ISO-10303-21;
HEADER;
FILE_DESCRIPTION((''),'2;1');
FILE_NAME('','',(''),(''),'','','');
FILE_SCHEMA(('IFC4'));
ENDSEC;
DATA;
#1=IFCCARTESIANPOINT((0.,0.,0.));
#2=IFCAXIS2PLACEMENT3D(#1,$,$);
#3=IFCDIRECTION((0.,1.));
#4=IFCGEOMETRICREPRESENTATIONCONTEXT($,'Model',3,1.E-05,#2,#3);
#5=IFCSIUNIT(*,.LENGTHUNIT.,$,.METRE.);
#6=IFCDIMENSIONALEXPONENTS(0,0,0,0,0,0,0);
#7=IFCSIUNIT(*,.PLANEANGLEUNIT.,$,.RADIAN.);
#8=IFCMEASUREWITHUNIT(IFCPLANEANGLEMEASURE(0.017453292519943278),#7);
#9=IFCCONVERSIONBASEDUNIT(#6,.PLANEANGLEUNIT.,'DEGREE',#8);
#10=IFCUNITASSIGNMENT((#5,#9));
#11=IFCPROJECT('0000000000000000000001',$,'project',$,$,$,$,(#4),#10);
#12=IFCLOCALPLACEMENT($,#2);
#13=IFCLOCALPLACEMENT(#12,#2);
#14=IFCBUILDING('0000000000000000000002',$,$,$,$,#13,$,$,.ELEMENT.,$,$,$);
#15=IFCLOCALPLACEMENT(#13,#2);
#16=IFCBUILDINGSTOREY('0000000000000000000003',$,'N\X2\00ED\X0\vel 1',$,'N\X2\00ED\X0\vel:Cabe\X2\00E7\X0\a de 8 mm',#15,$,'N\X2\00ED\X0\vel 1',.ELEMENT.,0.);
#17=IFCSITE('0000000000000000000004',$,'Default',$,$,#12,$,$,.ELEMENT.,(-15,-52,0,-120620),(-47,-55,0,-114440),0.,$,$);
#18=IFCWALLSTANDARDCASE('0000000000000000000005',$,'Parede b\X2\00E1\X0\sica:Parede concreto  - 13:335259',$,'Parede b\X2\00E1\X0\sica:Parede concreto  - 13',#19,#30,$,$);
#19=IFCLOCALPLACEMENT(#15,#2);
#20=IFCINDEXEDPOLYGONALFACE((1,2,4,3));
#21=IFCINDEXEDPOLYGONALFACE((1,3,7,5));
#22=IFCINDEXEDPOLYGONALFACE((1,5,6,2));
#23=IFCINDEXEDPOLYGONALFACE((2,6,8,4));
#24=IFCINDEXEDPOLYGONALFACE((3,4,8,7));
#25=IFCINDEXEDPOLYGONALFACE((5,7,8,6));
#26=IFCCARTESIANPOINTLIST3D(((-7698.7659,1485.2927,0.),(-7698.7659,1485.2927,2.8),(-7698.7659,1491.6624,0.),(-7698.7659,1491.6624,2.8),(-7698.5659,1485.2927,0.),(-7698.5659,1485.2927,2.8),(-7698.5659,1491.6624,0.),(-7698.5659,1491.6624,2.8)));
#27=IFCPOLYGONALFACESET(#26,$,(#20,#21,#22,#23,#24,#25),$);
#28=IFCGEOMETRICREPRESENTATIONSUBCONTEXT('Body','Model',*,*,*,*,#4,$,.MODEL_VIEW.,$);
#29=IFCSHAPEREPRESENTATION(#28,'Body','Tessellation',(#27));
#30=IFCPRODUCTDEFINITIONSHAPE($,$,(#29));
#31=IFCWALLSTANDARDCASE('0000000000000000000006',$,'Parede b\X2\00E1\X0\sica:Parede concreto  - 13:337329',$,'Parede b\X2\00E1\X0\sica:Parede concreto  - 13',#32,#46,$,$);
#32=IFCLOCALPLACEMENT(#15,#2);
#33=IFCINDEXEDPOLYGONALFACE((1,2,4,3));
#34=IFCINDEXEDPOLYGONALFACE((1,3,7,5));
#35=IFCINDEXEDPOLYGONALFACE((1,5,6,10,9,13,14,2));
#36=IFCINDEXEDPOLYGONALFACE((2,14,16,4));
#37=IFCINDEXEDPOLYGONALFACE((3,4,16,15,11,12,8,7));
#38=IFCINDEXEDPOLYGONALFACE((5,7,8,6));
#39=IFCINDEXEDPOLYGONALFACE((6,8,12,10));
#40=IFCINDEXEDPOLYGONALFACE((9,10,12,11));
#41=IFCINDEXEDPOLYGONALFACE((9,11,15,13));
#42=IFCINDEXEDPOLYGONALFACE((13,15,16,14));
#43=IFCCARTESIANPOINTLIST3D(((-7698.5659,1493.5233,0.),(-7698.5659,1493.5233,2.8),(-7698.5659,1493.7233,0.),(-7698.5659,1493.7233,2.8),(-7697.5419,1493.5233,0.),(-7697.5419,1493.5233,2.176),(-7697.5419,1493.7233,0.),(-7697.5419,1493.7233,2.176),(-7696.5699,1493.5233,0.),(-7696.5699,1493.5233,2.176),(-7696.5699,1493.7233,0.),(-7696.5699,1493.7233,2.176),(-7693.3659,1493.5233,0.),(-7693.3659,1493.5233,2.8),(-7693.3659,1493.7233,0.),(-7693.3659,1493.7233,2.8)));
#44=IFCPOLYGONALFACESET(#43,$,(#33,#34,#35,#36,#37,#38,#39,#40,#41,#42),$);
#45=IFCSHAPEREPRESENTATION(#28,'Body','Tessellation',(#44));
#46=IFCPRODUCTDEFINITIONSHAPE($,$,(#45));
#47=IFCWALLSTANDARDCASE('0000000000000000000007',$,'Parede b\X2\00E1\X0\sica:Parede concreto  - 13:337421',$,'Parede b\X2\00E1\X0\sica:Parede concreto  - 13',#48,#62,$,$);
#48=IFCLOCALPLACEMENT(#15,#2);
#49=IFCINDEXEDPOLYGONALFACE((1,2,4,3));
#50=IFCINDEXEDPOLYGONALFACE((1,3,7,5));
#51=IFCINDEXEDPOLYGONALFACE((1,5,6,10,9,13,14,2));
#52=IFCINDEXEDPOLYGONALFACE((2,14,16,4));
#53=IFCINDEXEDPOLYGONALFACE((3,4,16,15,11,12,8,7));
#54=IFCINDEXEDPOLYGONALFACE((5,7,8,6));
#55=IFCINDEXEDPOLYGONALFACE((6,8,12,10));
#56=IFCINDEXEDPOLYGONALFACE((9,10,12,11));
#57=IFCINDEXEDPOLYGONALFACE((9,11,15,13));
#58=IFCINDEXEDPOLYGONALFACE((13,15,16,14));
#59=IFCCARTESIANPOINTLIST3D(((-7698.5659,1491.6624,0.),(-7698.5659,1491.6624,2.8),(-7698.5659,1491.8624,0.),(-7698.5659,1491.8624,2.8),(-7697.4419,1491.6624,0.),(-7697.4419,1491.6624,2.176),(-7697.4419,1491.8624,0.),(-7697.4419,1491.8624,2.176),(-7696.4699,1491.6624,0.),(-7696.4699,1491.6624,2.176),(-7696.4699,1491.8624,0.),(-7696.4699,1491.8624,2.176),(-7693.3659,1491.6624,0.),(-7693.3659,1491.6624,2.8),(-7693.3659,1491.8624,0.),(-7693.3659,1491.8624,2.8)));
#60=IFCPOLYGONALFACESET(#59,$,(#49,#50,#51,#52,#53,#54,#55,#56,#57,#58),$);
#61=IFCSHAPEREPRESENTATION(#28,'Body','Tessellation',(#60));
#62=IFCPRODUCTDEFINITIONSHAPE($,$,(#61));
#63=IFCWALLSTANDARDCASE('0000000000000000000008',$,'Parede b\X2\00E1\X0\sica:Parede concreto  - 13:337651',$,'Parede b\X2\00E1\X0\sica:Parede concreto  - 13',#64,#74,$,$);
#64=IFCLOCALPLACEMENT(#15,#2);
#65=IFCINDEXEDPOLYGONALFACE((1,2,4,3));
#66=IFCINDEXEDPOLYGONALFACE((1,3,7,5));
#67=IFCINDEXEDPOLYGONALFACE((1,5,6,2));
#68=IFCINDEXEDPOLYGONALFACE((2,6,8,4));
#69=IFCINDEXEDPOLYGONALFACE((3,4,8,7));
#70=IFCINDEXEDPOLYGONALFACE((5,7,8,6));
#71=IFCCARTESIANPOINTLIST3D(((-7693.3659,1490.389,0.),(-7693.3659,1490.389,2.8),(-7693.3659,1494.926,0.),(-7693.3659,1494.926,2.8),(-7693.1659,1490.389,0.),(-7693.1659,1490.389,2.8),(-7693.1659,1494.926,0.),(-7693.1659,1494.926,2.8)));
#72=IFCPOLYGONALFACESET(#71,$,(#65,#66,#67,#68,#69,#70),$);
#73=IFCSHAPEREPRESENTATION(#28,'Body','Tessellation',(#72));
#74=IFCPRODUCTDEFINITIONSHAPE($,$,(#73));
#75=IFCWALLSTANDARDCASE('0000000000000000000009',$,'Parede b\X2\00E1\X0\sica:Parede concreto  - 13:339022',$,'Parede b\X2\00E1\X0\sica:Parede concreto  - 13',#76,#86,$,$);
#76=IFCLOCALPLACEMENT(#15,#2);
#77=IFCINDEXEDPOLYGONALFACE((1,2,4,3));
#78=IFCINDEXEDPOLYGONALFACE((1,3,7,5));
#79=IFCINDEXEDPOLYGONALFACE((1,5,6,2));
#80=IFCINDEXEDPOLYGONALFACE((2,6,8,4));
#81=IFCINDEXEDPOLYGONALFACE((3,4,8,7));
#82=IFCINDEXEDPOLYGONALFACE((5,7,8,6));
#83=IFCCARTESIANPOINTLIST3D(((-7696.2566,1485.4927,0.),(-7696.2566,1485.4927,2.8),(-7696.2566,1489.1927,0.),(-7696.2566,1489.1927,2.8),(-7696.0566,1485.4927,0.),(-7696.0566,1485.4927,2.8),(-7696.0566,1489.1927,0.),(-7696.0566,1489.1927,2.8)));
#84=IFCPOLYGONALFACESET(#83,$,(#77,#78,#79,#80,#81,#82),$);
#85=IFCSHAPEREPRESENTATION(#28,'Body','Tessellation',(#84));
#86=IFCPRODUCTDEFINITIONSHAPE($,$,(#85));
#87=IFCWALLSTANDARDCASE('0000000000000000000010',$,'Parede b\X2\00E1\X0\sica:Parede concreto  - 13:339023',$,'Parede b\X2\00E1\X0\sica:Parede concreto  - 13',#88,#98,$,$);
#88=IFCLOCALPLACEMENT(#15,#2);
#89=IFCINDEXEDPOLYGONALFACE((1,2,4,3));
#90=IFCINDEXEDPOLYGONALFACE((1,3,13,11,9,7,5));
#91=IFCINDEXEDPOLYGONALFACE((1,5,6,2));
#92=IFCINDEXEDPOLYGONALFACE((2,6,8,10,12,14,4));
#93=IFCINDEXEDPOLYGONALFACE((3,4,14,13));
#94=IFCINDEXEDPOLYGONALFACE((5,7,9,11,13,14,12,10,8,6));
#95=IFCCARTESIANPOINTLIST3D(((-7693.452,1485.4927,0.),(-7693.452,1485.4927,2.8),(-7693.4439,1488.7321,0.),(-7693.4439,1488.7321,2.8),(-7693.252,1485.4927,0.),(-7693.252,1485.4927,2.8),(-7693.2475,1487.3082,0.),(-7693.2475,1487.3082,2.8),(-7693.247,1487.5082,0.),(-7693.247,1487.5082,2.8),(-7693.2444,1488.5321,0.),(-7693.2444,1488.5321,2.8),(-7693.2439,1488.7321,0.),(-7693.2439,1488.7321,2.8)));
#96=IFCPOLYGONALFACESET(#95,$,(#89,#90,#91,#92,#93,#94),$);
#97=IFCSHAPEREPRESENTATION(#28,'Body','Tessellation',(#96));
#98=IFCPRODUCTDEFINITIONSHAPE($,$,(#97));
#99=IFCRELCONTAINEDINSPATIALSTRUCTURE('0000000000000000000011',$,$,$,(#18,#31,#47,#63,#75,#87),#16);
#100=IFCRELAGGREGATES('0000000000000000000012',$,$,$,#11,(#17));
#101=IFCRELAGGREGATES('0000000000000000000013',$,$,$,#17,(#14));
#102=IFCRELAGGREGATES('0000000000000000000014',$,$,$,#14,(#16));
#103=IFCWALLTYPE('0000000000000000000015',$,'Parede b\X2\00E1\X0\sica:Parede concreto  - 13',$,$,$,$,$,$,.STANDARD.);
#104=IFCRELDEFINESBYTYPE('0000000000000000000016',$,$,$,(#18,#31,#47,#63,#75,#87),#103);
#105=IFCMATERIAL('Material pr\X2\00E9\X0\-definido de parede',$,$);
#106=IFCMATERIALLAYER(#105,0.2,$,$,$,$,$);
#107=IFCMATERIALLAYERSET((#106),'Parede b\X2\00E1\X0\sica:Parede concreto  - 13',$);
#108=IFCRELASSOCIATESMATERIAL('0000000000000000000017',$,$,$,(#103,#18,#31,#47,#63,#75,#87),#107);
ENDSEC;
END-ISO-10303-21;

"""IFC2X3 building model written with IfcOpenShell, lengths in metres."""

from ifc_helpers import new_model, entity, si_unit, converted_unit, direction, frame, frame_2d, origin, place, context, subcontext, project, spatial, polyline, rectangle, outline, extrude, material, layer, layer_set, layer_usage, type_object, element, save


model = new_model("IFC2X3")

# Units and contexts
model_context = context("Model", 3, precision=1e-05, world=origin(), true_north=direction((0.0, 1.0)))
body_context = subcontext(model_context, "Body", "Model", "MODEL_VIEW")
ifc_project = project(units=[si_unit("LENGTHUNIT", "METRE"), converted_unit("PLANEANGLEUNIT", "DEGREE", entity("IfcPlaneAngleMeasure", 0.017453292519943278), si_unit("PLANEANGLEUNIT", "RADIAN"), dimensions=[0, 0, 0, 0, 0, 0, 0])], contexts=[model_context])

# Site, building, storey
site_placement = place(None, origin())
site = spatial("IfcSite", under=ifc_project, at=site_placement, Name="Default", CompositionType="ELEMENT", RefLatitude=(-15, -52, 0, -120620), RefLongitude=(-47, -55, 0, -114440), RefElevation=0.0)
building_placement = place(site_placement, origin())
building = spatial("IfcBuilding", under=site, at=building_placement, CompositionType="ELEMENT")
storey_placement = place(building_placement, origin())
storey = spatial("IfcBuildingStorey", under=building, at=storey_placement, Name="Nível 1", ObjectType="Nível:Cabeça de 8 mm", LongName="Nível 1", CompositionType="ELEMENT", Elevation=0.0)

# Shared definitions
ifc_material_1 = material(Name="Material pré-definido de parede")
ifc_layer = layer(ifc_material_1, 0.2)
ifc_layer_set = layer_set([ifc_layer], Name="Parede básica:Parede concreto  - 13")
wall_type = type_object("IfcWallType", Name="Parede básica:Parede concreto  - 13", PredefinedType="STANDARD", material=ifc_layer_set)

# Wall
ifc_layer_usage_1 = layer_usage(ifc_layer_set, "AXIS2", "NEGATIVE", 0.1)
wall_1_placement = place(storey_placement, frame((-7698.6659, 1491.6624, 0.0), z_axis=(0.0, 0.0, 1.0), x_axis=(0.0, -1.0, 0.0)))
element("IfcWallStandardCase", 1, at=wall_1_placement, inside=storey, type_object=wall_type, material=ifc_layer_usage_1, Name="Parede básica:Parede concreto  - 13:335259", ObjectType="Parede básica:Parede concreto  - 13", context=body_context, shape_type="SweptSolid", body=[
    extrude(rectangle(XDim=6.3697, YDim=0.2, at=frame_2d((3.1848, 0.0), x_axis=(-1.0, 0.0))), origin(), (0.0, 0.0, 1.0), 2.8),
])

# Walls, openings
ifc_layer_usage_2 = layer_usage(ifc_layer_set, "AXIS2", "NEGATIVE", 0.1)
wall_2_placement = place(storey_placement, frame((-7698.5659, 1493.6233, 0.0)))
wall_2 = element("IfcWallStandardCase", 2, at=wall_2_placement, inside=storey, type_object=wall_type, material=ifc_layer_usage_2, Name="Parede básica:Parede concreto  - 13:337329", ObjectType="Parede básica:Parede concreto  - 13", context=body_context, shape_type="SweptSolid", body=[
    extrude(rectangle(XDim=5.2, YDim=0.2, at=frame_2d((2.6, 0.0), x_axis=(-1.0, 0.0))), origin(), (0.0, 0.0, 1.0), 2.8),
])
opening_1_placement = place(wall_2_placement, origin())
element("IfcOpeningElement", 3, at=opening_1_placement, cuts=wall_2, ObjectType="Opening", context=body_context, shape_type="SweptSolid", body=[
    extrude(rectangle(XDim=2.176, YDim=0.972, at=frame_2d((0.0, 0.0), x_axis=(0.0, 1.0))), frame((1.51, 0.1, 1.088), z_axis=(0.0, -1.0, 0.0), x_axis=(1.0, 0.0, 0.0)), (0.0, 0.0, 1.0), 0.2),
])
ifc_layer_usage_3 = layer_usage(ifc_layer_set, "AXIS2", "POSITIVE", -0.1)
wall_3_placement = place(storey_placement, frame((-7698.5659, 1491.7624, 0.0)))
wall_3 = element("IfcWallStandardCase", 4, at=wall_3_placement, inside=storey, type_object=wall_type, material=ifc_layer_usage_3, Name="Parede básica:Parede concreto  - 13:337421", ObjectType="Parede básica:Parede concreto  - 13", context=body_context, shape_type="SweptSolid", body=[
    extrude(rectangle(XDim=5.2, YDim=0.2, at=frame_2d((2.6, 0.0), x_axis=(-1.0, 0.0))), origin(), (0.0, 0.0, 1.0), 2.8),
])
opening_2_placement = place(wall_3_placement, origin())
element("IfcOpeningElement", 5, at=opening_2_placement, cuts=wall_3, ObjectType="Opening", context=body_context, shape_type="SweptSolid", body=[
    extrude(rectangle(XDim=2.176, YDim=0.972, at=frame_2d((0.0, 0.0), x_axis=(0.0, 1.0))), frame((1.61, 0.1, 1.088), z_axis=(0.0, -1.0, 0.0), x_axis=(1.0, 0.0, 0.0)), (0.0, 0.0, 1.0), 0.2),
])

# Wall
ifc_layer_usage_4 = layer_usage(ifc_layer_set, "AXIS2", "NEGATIVE", 0.1)
wall_4_placement = place(storey_placement, frame((-7693.2659, 1490.389, 0.0), z_axis=(0.0, 0.0, 1.0), x_axis=(0.0, 1.0, 0.0)))
element("IfcWallStandardCase", 6, at=wall_4_placement, inside=storey, type_object=wall_type, material=ifc_layer_usage_4, Name="Parede básica:Parede concreto  - 13:337651", ObjectType="Parede básica:Parede concreto  - 13", context=body_context, shape_type="SweptSolid", body=[
    extrude(rectangle(XDim=4.537, YDim=0.2, at=frame_2d((2.2685, 0.0), x_axis=(-1.0, 0.0))), origin(), (0.0, 0.0, 1.0), 2.8),
])

# Walls
ifc_layer_usage_5 = layer_usage(ifc_layer_set, "AXIS2", "POSITIVE", -0.1)
wall_5_placement = place(storey_placement, frame((-7696.1566, 1485.4927, 0.0), z_axis=(0.0, 0.0, 1.0), x_axis=(0.0, 1.0, 0.0)))
element("IfcWallStandardCase", 7, at=wall_5_placement, inside=storey, type_object=wall_type, material=ifc_layer_usage_5, Name="Parede básica:Parede concreto  - 13:339022", ObjectType="Parede básica:Parede concreto  - 13", context=body_context, shape_type="SweptSolid", body=[
    extrude(rectangle(XDim=3.7, YDim=0.2, at=frame_2d((1.85, 0.0), x_axis=(-1.0, 0.0))), origin(), (0.0, 0.0, 1.0), 2.8),
])
ifc_layer_usage_6 = layer_usage(ifc_layer_set, "AXIS2", "POSITIVE", -0.1)
wall_6_placement = place(storey_placement, frame((-7693.352, 1485.4925, 0.0), z_axis=(0.0, 0.0, 1.0), x_axis=(0.002512, 0.999997, 0.0)))
element("IfcWallStandardCase", 8, at=wall_6_placement, inside=storey, type_object=wall_type, material=ifc_layer_usage_6, Name="Parede básica:Parede concreto  - 13:339023", ObjectType="Parede básica:Parede concreto  - 13", context=body_context, shape_type="SweptSolid", body=[
    extrude(outline(polyline([(3.2399, -0.1), (3.2394, 0.1), (0.0, 0.1), (0.0005, -0.1), (1.8159, -0.1), (2.0159, -0.1), (3.0399, -0.1), (3.2399, -0.1)])), origin(), (0.0, 0.0, 1.0), 2.8),
])

save(model, "model.ifc")
